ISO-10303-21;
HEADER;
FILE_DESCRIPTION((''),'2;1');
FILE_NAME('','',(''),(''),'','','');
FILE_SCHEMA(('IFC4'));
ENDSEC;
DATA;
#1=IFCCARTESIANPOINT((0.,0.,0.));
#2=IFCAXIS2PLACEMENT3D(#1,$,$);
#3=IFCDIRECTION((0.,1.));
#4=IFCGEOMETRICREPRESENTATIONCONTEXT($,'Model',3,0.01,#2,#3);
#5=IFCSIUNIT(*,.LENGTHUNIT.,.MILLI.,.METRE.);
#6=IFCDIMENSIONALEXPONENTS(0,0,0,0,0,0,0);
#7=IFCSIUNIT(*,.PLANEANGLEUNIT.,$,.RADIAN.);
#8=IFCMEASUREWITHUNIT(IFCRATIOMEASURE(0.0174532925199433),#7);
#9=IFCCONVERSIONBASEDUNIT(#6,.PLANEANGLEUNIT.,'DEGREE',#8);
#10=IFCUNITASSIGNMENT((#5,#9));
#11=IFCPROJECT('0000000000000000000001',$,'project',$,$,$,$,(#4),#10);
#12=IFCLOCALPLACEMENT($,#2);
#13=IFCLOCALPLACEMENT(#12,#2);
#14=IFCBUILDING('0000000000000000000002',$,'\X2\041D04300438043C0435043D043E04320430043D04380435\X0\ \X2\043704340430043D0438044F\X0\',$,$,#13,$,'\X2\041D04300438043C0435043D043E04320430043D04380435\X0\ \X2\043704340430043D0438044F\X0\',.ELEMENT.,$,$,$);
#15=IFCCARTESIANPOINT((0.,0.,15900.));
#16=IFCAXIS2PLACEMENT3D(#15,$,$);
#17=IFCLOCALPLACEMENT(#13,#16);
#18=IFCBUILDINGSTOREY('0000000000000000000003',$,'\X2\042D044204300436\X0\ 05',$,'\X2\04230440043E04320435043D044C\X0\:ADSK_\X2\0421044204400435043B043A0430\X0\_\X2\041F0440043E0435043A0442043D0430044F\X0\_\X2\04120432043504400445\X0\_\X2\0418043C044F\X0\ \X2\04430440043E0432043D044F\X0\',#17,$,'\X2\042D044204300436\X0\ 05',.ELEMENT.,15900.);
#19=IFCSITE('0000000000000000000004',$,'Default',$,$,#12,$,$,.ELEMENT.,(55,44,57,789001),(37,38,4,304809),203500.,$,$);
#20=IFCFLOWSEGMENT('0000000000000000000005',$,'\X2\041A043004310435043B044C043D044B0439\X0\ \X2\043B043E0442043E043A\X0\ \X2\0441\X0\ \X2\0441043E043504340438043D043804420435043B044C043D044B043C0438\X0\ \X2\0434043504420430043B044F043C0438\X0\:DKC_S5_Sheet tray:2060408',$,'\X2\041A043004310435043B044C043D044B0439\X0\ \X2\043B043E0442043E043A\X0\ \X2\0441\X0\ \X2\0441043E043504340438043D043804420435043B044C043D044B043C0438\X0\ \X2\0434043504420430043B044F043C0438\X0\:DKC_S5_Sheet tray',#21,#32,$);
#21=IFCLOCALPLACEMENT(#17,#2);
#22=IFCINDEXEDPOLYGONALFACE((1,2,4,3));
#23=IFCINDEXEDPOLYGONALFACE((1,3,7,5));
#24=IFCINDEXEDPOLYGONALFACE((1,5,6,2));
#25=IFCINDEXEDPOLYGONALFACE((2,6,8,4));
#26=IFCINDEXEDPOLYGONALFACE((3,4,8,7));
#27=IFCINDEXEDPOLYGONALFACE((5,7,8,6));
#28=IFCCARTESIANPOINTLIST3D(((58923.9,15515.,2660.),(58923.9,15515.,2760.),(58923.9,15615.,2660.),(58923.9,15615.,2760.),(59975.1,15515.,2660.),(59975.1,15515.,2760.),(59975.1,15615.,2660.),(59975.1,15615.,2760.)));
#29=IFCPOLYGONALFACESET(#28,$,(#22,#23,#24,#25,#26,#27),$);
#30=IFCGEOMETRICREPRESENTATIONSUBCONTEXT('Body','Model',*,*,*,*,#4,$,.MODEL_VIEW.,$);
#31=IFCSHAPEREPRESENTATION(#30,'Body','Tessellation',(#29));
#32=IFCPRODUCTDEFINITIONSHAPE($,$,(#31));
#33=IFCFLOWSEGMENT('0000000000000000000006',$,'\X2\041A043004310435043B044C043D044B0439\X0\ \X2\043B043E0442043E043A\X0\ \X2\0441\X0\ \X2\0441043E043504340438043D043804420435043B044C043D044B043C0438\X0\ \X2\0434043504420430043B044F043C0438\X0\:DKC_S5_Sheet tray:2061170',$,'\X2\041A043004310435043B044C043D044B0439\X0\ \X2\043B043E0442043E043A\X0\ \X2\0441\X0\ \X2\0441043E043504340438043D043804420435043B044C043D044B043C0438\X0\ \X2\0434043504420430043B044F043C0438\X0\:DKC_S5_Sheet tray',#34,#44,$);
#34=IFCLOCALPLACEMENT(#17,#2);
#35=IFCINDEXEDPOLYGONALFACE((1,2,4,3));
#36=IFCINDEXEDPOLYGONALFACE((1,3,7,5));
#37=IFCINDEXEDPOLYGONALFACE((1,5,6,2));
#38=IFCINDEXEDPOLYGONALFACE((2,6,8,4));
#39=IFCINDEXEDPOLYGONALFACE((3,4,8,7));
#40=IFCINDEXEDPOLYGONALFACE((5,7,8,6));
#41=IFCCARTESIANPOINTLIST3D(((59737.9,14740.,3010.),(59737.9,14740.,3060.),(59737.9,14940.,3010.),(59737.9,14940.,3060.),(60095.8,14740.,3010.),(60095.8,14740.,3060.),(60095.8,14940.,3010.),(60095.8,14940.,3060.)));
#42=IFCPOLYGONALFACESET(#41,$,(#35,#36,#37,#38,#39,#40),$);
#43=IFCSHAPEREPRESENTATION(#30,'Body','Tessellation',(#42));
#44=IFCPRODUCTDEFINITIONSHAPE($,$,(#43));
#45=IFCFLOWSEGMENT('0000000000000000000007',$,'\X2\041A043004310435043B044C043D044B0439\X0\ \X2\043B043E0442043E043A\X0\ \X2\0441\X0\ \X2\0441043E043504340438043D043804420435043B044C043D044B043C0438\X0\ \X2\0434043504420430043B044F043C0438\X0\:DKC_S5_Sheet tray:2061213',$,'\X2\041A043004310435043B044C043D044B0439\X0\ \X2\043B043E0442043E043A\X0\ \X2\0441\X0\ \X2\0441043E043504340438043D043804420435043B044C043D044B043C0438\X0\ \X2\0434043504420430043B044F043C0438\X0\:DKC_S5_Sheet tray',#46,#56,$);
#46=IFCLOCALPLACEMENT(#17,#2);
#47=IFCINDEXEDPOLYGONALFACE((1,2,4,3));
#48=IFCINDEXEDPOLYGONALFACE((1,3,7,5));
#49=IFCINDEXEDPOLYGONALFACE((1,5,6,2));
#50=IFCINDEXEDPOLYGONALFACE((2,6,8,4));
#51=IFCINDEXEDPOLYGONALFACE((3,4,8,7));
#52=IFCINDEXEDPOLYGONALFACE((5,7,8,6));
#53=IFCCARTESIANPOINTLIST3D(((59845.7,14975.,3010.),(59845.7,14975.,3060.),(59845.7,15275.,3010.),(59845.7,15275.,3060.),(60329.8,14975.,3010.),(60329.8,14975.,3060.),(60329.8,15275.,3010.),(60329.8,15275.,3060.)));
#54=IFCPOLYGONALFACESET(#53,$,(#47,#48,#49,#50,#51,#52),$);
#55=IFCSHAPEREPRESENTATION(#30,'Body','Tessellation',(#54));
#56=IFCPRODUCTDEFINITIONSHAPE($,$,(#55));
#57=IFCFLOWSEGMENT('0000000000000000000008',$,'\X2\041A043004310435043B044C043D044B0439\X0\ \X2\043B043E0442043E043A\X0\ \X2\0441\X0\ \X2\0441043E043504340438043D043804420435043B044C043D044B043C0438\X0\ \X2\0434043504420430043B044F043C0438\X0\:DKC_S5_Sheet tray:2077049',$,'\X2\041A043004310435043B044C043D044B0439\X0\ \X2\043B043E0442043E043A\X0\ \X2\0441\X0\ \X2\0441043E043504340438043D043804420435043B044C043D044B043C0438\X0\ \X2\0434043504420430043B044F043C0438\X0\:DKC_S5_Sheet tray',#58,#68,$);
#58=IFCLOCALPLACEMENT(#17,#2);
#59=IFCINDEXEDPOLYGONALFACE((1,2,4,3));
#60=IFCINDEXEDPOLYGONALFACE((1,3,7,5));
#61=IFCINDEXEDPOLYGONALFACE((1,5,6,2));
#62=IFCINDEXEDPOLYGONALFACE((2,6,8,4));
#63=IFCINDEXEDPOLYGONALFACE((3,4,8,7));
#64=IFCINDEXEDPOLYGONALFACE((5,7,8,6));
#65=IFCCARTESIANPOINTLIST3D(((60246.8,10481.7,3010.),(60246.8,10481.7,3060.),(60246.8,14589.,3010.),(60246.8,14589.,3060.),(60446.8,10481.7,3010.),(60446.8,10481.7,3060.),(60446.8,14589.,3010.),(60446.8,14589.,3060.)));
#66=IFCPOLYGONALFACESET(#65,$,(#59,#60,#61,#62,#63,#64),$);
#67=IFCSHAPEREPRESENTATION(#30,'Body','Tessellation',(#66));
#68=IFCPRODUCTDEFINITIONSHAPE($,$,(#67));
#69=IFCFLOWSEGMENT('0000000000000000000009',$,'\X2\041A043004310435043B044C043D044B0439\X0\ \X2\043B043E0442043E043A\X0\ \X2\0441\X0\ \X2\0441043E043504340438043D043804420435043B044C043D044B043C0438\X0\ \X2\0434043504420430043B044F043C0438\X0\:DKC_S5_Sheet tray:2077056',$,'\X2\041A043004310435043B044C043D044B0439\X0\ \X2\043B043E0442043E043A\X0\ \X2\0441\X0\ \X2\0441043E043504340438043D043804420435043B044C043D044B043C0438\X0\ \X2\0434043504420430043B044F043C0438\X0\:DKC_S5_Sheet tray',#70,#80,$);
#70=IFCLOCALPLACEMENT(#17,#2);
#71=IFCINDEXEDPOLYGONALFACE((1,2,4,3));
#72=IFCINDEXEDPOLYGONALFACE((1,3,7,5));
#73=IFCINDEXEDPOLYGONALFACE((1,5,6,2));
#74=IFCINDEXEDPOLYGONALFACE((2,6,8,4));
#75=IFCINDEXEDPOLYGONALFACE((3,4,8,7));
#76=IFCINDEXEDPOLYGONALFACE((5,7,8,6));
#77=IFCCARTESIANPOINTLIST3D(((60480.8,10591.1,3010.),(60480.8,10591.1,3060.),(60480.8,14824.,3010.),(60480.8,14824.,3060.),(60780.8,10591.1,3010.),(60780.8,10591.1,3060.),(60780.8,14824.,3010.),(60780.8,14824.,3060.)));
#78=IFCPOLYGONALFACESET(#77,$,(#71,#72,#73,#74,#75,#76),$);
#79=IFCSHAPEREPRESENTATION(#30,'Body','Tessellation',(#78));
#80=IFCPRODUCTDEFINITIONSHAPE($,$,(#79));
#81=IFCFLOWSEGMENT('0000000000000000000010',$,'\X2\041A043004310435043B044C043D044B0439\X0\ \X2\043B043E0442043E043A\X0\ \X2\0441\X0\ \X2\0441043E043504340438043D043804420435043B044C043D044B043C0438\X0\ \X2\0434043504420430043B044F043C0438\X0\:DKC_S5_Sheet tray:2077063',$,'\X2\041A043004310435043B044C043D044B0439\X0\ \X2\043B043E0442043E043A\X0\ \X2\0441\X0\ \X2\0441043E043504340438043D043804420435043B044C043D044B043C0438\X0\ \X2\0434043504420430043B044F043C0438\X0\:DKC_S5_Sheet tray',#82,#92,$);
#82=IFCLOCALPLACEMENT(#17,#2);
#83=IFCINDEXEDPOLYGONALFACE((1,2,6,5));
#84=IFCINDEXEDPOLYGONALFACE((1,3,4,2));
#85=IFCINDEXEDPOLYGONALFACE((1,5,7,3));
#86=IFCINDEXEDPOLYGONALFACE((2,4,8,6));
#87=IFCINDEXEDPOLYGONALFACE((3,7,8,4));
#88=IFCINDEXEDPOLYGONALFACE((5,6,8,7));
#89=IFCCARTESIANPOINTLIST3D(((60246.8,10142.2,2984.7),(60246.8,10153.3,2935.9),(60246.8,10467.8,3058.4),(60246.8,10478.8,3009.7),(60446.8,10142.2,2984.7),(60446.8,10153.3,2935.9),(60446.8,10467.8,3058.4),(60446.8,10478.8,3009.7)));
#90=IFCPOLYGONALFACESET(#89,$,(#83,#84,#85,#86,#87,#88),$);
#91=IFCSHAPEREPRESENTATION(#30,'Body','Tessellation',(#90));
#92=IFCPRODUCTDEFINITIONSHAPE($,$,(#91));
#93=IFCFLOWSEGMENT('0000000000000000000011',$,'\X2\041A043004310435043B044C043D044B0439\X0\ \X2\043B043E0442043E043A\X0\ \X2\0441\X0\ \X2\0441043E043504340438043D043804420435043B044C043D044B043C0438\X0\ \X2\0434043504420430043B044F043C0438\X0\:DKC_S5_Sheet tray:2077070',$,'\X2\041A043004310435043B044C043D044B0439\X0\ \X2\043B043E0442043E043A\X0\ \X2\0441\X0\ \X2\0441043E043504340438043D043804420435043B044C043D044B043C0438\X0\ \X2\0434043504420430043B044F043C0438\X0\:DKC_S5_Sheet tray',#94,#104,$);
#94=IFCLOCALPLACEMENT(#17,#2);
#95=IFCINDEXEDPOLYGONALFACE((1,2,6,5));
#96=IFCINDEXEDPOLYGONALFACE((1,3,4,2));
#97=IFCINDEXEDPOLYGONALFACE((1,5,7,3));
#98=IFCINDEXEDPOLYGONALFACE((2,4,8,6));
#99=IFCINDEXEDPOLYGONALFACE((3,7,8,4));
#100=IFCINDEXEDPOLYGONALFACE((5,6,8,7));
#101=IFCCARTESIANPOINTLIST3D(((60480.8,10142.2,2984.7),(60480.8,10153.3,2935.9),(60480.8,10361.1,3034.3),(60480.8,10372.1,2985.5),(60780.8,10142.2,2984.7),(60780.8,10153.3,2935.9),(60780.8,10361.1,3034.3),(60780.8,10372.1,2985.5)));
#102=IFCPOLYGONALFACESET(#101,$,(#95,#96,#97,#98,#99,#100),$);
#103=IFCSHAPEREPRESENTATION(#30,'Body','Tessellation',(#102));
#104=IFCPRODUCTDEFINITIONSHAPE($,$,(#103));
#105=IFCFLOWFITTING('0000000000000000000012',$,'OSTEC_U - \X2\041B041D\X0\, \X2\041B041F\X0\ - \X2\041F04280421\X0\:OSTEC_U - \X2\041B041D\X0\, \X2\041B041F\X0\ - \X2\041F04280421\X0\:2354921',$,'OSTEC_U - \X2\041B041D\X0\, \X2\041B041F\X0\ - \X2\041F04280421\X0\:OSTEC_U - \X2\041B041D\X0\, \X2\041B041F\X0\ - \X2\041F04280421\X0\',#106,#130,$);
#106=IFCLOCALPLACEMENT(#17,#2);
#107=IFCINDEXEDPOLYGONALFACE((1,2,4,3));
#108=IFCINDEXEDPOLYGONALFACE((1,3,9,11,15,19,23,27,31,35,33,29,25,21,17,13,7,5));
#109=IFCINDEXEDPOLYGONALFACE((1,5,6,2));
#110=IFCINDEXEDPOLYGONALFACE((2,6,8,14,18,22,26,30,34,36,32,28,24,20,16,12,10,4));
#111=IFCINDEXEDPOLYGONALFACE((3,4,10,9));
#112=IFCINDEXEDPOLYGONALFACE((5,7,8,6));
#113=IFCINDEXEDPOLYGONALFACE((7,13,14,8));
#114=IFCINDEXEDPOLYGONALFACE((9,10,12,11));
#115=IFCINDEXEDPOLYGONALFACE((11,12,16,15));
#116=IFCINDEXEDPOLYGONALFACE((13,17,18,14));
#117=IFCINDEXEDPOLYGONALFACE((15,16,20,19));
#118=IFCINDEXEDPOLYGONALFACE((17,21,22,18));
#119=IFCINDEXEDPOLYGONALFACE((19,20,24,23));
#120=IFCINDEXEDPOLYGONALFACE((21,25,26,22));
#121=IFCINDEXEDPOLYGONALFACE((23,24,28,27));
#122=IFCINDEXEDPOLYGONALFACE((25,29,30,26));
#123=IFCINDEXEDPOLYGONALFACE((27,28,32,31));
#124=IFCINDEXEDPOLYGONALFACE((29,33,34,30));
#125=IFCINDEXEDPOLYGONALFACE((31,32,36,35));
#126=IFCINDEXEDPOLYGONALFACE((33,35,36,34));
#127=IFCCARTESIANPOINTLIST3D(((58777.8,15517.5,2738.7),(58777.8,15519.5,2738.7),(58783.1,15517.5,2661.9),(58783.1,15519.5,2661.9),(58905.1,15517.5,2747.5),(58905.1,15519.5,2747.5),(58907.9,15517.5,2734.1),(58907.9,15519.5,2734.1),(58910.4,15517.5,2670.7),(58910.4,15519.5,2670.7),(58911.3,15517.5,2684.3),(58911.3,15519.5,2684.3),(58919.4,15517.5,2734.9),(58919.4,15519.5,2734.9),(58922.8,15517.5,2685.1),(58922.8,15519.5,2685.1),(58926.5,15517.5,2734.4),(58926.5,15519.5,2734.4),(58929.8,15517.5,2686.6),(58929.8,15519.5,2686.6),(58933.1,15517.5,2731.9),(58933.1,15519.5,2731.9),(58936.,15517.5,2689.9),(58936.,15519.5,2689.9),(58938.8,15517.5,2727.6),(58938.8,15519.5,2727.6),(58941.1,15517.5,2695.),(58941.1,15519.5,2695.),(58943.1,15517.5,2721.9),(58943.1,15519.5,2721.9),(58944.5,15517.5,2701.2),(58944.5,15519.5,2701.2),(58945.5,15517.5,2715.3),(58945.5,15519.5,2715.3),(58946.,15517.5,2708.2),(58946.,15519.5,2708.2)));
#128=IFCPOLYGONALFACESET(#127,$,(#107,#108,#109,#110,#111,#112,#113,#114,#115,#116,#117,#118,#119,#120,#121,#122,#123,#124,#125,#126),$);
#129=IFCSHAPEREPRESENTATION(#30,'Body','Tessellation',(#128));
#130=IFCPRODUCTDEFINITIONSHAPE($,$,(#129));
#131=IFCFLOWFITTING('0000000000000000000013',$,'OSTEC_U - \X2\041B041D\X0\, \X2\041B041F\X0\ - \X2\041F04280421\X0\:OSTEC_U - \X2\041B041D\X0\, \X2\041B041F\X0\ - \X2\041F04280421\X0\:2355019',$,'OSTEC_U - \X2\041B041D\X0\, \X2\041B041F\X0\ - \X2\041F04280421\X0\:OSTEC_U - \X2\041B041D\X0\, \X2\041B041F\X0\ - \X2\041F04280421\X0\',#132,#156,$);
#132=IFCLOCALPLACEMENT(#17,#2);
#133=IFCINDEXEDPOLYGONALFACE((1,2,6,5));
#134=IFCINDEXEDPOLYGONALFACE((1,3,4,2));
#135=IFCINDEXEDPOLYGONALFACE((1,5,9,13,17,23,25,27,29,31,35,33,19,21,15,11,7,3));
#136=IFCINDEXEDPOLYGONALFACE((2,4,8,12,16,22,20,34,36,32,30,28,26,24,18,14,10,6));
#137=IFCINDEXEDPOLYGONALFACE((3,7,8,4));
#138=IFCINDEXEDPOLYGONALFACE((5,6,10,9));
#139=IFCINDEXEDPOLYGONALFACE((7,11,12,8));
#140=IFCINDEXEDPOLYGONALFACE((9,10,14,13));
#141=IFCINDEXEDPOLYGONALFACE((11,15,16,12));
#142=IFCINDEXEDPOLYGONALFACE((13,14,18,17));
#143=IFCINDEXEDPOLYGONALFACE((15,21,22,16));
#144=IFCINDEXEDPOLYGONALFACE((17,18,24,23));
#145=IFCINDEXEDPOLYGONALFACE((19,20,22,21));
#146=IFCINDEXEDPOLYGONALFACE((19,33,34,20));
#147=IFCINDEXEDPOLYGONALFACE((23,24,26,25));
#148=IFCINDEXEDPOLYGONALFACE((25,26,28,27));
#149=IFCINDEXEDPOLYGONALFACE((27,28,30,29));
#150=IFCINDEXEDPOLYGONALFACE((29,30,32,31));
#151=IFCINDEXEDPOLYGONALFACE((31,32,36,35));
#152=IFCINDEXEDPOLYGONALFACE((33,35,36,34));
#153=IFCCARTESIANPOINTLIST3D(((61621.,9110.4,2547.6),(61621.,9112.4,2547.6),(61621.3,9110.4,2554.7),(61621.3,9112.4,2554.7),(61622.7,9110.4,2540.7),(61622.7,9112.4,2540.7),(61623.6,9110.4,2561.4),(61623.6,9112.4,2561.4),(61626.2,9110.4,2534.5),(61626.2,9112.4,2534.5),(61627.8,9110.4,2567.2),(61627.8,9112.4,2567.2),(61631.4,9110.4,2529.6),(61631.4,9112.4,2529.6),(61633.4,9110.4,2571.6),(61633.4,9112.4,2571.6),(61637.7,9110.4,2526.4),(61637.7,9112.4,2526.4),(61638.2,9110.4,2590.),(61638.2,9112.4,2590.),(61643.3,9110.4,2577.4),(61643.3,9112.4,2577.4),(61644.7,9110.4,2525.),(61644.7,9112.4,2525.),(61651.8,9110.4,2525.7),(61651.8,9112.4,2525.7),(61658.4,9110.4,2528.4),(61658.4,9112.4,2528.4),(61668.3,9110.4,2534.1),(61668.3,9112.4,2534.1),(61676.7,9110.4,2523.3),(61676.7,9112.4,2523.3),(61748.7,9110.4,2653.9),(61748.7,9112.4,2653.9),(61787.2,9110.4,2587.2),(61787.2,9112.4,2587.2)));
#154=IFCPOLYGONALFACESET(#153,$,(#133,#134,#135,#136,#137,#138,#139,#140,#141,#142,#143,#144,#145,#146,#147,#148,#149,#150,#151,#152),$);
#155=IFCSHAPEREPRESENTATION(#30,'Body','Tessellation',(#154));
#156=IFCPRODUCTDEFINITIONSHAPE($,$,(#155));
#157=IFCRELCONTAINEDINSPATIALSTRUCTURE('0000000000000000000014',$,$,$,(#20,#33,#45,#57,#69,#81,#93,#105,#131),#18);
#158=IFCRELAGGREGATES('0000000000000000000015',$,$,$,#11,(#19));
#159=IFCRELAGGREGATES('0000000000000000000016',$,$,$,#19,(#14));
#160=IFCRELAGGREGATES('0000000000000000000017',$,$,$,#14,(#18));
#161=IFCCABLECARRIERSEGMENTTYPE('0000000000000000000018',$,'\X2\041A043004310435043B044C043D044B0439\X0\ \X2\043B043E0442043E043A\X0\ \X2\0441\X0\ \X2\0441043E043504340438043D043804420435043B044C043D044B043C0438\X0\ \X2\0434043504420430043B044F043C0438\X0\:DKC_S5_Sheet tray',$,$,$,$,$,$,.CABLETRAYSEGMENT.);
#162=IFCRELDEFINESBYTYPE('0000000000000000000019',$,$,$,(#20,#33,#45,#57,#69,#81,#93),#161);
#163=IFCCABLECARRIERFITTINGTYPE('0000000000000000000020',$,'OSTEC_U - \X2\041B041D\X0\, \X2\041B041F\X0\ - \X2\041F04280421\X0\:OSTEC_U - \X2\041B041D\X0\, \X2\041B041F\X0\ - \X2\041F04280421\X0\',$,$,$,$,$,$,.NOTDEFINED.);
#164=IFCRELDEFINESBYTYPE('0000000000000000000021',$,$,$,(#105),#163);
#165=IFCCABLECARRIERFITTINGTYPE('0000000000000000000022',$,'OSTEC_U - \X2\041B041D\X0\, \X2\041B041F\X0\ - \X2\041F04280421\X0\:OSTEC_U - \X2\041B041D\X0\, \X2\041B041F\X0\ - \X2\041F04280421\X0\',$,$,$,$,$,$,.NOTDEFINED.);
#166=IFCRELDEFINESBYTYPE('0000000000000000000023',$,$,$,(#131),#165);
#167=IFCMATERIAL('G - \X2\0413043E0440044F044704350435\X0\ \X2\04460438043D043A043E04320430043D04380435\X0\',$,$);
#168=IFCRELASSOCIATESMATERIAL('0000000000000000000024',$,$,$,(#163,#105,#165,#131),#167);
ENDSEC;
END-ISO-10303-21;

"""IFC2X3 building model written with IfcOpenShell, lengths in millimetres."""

from ifc_helpers import new_model, entity, si_unit, converted_unit, direction, frame, frame_2d, origin, origin_2d_with_axis, place, context, subcontext, project, spatial, polyline, circle_curve, parameter, trimmed, segment, composite_curve, rectangle, outline, extrude, source, transform, mapped, material, type_object, type_shapes, element, save


model = new_model("IFC2X3")

# Units and contexts
model_context = context("Model", 3, precision=0.01, world=origin(), true_north=direction((0.0, 1.0)))
body_context = subcontext(model_context, "Body", "Model", "MODEL_VIEW")
ifc_project = project(units=[si_unit("LENGTHUNIT", "METRE", prefix="MILLI"), converted_unit("PLANEANGLEUNIT", "DEGREE", entity("IfcRatioMeasure", 0.0174532925199433), si_unit("PLANEANGLEUNIT", "RADIAN"), dimensions=[0, 0, 0, 0, 0, 0, 0])], contexts=[model_context])

# Site, building, storey
site_placement = place(None, frame((0.0, 0.0, 0.0)))
site = spatial("IfcSite", under=ifc_project, at=site_placement, Name="Default", CompositionType="ELEMENT", RefLatitude=(55, 44, 57, 789001), RefLongitude=(37, 38, 4, 304809), RefElevation=203500.0)
building_placement = place(site_placement, origin())
building = spatial("IfcBuilding", under=site, at=building_placement, Name="Наименование здания", LongName="Наименование здания", CompositionType="ELEMENT")
storey_placement = place(building_placement, frame((0.0, 0.0, 15900.0)))
storey = spatial("IfcBuildingStorey", under=building, at=storey_placement, Name="Этаж 05", ObjectType="Уровень:ADSK_Стрелка_Проектная_Вверх_Имя уровня", LongName="Этаж 05", CompositionType="ELEMENT", Elevation=15900.0)

# Flow segments
cable_carrier_segment_type = type_object("IfcCableCarrierSegmentType", Name="Кабельный лоток с соединительными деталями:DKC_S5_Sheet tray", PredefinedType="CABLETRAYSEGMENT")
flow_segment_1_placement = place(storey_placement, frame((58923.9, 15515.0, 2660.0)))
element("IfcFlowSegment", 1, at=flow_segment_1_placement, inside=storey, type_object=cable_carrier_segment_type, Name="Кабельный лоток с соединительными деталями:DKC_S5_Sheet tray:2060408", ObjectType="Кабельный лоток с соединительными деталями:DKC_S5_Sheet tray", context=body_context, shape_type="SweptSolid", body=[
    extrude(rectangle(XDim=1051.1, YDim=100.0, at=frame_2d((0.0, 0.0), x_axis=(1.0, 0.0))), frame((525.6, 50.0, 0.0), z_axis=(0.0, 0.0, 1.0), x_axis=(-1.0, 0.0, 0.0)), (0.0, 0.0, 1.0), 100.0),
])
flow_segment_2_placement = place(storey_placement, frame((59737.9, 14740.0, 3010.0)))
element("IfcFlowSegment", 2, at=flow_segment_2_placement, inside=storey, type_object=cable_carrier_segment_type, Name="Кабельный лоток с соединительными деталями:DKC_S5_Sheet tray:2061170", ObjectType="Кабельный лоток с соединительными деталями:DKC_S5_Sheet tray", context=body_context, shape_type="SweptSolid", body=[
    extrude(rectangle(XDim=357.9, YDim=200.0, at=frame_2d((0.0, 0.0), x_axis=(1.0, 0.0))), frame((178.9, 100.0, 0.0), z_axis=(0.0, 0.0, 1.0), x_axis=(-1.0, 0.0, 0.0)), (0.0, 0.0, 1.0), 50.0),
])
flow_segment_3_placement = place(storey_placement, frame((59845.7, 14975.0, 3010.0)))
element("IfcFlowSegment", 3, at=flow_segment_3_placement, inside=storey, type_object=cable_carrier_segment_type, Name="Кабельный лоток с соединительными деталями:DKC_S5_Sheet tray:2061213", ObjectType="Кабельный лоток с соединительными деталями:DKC_S5_Sheet tray", context=body_context, shape_type="SweptSolid", body=[
    extrude(rectangle(XDim=484.2, YDim=300.0, at=frame_2d((0.0, 0.0), x_axis=(1.0, 0.0))), frame((242.1, 150.0, 0.0), z_axis=(0.0, 0.0, 1.0), x_axis=(-1.0, 0.0, 0.0)), (0.0, 0.0, 1.0), 50.0),
])
flow_segment_4_placement = place(storey_placement, frame((60246.8, 10481.7, 3010.0)))
element("IfcFlowSegment", 4, at=flow_segment_4_placement, inside=storey, type_object=cable_carrier_segment_type, Name="Кабельный лоток с соединительными деталями:DKC_S5_Sheet tray:2077049", ObjectType="Кабельный лоток с соединительными деталями:DKC_S5_Sheet tray", context=body_context, shape_type="SweptSolid", body=[
    extrude(rectangle(XDim=4107.4, YDim=200.0, at=origin_2d_with_axis()), frame((100.0, 2053.7, 0.0), z_axis=(0.0, 0.0, 1.0), x_axis=(0.0, -1.0, 0.0)), (0.0, 0.0, 1.0), 50.0),
])
flow_segment_5_placement = place(storey_placement, frame((60480.8, 10591.1, 3010.0)))
element("IfcFlowSegment", 5, at=flow_segment_5_placement, inside=storey, type_object=cable_carrier_segment_type, Name="Кабельный лоток с соединительными деталями:DKC_S5_Sheet tray:2077056", ObjectType="Кабельный лоток с соединительными деталями:DKC_S5_Sheet tray", context=body_context, shape_type="SweptSolid", body=[
    extrude(rectangle(XDim=4233.0, YDim=300.0, at=origin_2d_with_axis()), frame((150.0, 2116.5, 0.0), z_axis=(0.0, 0.0, 1.0), x_axis=(0.0, -1.0, 0.0)), (0.0, 0.0, 1.0), 50.0),
])
flow_segment_6_placement = place(storey_placement, frame((60246.8, 10142.2, 2935.9)))
element("IfcFlowSegment", 6, at=flow_segment_6_placement, inside=storey, type_object=cable_carrier_segment_type, Name="Кабельный лоток с соединительными деталями:DKC_S5_Sheet tray:2077063", ObjectType="Кабельный лоток с соединительными деталями:DKC_S5_Sheet tray", context=body_context, shape_type="SweptSolid", body=[
    extrude(rectangle(XDim=50.0, YDim=333.8, at=frame_2d((0.0, 0.0), x_axis=(0.0, 1.0))), frame((0.0, 168.3, 61.3), z_axis=(1.0, 0.0, 0.0), x_axis=(0.0, -0.975284, -0.220956)), (0.0, 0.0, 1.0), 200.0),
])
flow_segment_7_placement = place(storey_placement, frame((60480.8, 10142.2, 2935.9)))
element("IfcFlowSegment", 7, at=flow_segment_7_placement, inside=storey, type_object=cable_carrier_segment_type, Name="Кабельный лоток с соединительными деталями:DKC_S5_Sheet tray:2077070", ObjectType="Кабельный лоток с соединительными деталями:DKC_S5_Sheet tray", context=body_context, shape_type="SweptSolid", body=[
    extrude(rectangle(XDim=50.0, YDim=224.4, at=frame_2d((0.0, 0.0), x_axis=(0.0, 1.0))), frame((0.0, 114.9, 49.2), z_axis=(1.0, 0.0, 0.0), x_axis=(0.0, 0.975284, 0.220956)), (0.0, 0.0, 1.0), 300.0),
])

# Flow fittings
ifc_material_1 = material(Name="G - Горячее цинкование")
cable_carrier_fitting_type_1 = type_object("IfcCableCarrierFittingType", Name="OSTEC_U - ЛН, ЛП - ПШС:OSTEC_U - ЛН, ЛП - ПШС", PredefinedType="NOTDEFINED", material=ifc_material_1)
shared_shape_1 = source(origin(), body_context, "Body", "SweptSolid", [
    extrude(outline(composite_curve([segment(trimmed(circle_curve(frame_2d((-41.5, 0.0), x_axis=(1.0, 0.0)), 25.0), [parameter(90.0)], [parameter(270.0)], True, "PARAMETER"), True, "CONTINUOUS"), segment(polyline([(-41.5, -25.0), (-30.0, -25.0)]), True, "CONTINUOUS"), segment(polyline([(-30.0, -25.0), (-28.1, -38.5)]), True, "CONTINUOUS"), segment(polyline([(-28.1, -38.5), (99.5, -38.5)]), True, "CONTINUOUS"), segment(polyline([(99.5, -38.5), (99.5, 38.5)]), True, "CONTINUOUS"), segment(polyline([(99.5, 38.5), (-28.1, 38.5)]), True, "CONTINUOUS"), segment(polyline([(-28.1, 38.5), (-30.0, 25.0)]), True, "CONTINUOUS"), segment(polyline([(-30.0, 25.0), (-41.5, 25.0)]), True, "CONTINUOUS")], self_intersect=False)), frame((41.5, 0.0, 0.0), z_axis=(0.0, 0.0, -1.0), x_axis=(1.0, 0.0, 0.0)), (0.0, 0.0, -1.0), 2.0),
])
type_shapes(cable_carrier_fitting_type_1, [shared_shape_1])
flow_fitting_1_placement = place(storey_placement, frame((58921.1, 15519.5, 2710.0), z_axis=(0.0, -1.0, 0.0), x_axis=(-0.997626, 0.0, -0.068859)))
element("IfcFlowFitting", 8, at=flow_fitting_1_placement, inside=storey, type_object=cable_carrier_fitting_type_1, material=ifc_material_1, Name="OSTEC_U - ЛН, ЛП - ПШС:OSTEC_U - ЛН, ЛП - ПШС:2354921", ObjectType="OSTEC_U - ЛН, ЛП - ПШС:OSTEC_U - ЛН, ЛП - ПШС", context=body_context, shape_type="MappedRepresentation", body=[
    mapped(shared_shape_1, transform((0.0, 0.0, 0.0), scale=1.0)),
])
cable_carrier_fitting_type_2 = type_object("IfcCableCarrierFittingType", Name="OSTEC_U - ЛН, ЛП - ПШС:OSTEC_U - ЛН, ЛП - ПШС", PredefinedType="NOTDEFINED", material=ifc_material_1)
shared_shape_2 = source(origin(), body_context, "Body", "SweptSolid", [
    extrude(outline(composite_curve([segment(trimmed(circle_curve(frame_2d((-41.5, 0.0), x_axis=(1.0, 0.0)), 25.0), [parameter(90.0)], [parameter(270.0)], True, "PARAMETER"), True, "CONTINUOUS"), segment(polyline([(-41.5, -25.0), (-30.0, -25.0)]), True, "CONTINUOUS"), segment(polyline([(-30.0, -25.0), (-28.1, -38.5)]), True, "CONTINUOUS"), segment(polyline([(-28.1, -38.5), (99.5, -38.5)]), True, "CONTINUOUS"), segment(polyline([(99.5, -38.5), (99.5, 38.5)]), True, "CONTINUOUS"), segment(polyline([(99.5, 38.5), (-28.1, 38.5)]), True, "CONTINUOUS"), segment(polyline([(-28.1, 38.5), (-30.0, 25.0)]), True, "CONTINUOUS"), segment(polyline([(-30.0, 25.0), (-41.5, 25.0)]), True, "CONTINUOUS")], self_intersect=False)), frame((41.5, 0.0, 0.0)), (0.0, 0.0, 1.0), 2.0),
])
type_shapes(cable_carrier_fitting_type_2, [shared_shape_2])
flow_fitting_2_placement = place(storey_placement, frame((61645.9, 9110.4, 2550.0), z_axis=(0.0, 1.0, 0.0), x_axis=(0.865893, 0.0, 0.500229)))
element("IfcFlowFitting", 9, at=flow_fitting_2_placement, inside=storey, type_object=cable_carrier_fitting_type_2, material=ifc_material_1, Name="OSTEC_U - ЛН, ЛП - ПШС:OSTEC_U - ЛН, ЛП - ПШС:2355019", ObjectType="OSTEC_U - ЛН, ЛП - ПШС:OSTEC_U - ЛН, ЛП - ПШС", context=body_context, shape_type="MappedRepresentation", body=[
    mapped(shared_shape_2, transform((0.0, 0.0, 0.0), scale=1.0)),
])

save(model, "model.ifc")
